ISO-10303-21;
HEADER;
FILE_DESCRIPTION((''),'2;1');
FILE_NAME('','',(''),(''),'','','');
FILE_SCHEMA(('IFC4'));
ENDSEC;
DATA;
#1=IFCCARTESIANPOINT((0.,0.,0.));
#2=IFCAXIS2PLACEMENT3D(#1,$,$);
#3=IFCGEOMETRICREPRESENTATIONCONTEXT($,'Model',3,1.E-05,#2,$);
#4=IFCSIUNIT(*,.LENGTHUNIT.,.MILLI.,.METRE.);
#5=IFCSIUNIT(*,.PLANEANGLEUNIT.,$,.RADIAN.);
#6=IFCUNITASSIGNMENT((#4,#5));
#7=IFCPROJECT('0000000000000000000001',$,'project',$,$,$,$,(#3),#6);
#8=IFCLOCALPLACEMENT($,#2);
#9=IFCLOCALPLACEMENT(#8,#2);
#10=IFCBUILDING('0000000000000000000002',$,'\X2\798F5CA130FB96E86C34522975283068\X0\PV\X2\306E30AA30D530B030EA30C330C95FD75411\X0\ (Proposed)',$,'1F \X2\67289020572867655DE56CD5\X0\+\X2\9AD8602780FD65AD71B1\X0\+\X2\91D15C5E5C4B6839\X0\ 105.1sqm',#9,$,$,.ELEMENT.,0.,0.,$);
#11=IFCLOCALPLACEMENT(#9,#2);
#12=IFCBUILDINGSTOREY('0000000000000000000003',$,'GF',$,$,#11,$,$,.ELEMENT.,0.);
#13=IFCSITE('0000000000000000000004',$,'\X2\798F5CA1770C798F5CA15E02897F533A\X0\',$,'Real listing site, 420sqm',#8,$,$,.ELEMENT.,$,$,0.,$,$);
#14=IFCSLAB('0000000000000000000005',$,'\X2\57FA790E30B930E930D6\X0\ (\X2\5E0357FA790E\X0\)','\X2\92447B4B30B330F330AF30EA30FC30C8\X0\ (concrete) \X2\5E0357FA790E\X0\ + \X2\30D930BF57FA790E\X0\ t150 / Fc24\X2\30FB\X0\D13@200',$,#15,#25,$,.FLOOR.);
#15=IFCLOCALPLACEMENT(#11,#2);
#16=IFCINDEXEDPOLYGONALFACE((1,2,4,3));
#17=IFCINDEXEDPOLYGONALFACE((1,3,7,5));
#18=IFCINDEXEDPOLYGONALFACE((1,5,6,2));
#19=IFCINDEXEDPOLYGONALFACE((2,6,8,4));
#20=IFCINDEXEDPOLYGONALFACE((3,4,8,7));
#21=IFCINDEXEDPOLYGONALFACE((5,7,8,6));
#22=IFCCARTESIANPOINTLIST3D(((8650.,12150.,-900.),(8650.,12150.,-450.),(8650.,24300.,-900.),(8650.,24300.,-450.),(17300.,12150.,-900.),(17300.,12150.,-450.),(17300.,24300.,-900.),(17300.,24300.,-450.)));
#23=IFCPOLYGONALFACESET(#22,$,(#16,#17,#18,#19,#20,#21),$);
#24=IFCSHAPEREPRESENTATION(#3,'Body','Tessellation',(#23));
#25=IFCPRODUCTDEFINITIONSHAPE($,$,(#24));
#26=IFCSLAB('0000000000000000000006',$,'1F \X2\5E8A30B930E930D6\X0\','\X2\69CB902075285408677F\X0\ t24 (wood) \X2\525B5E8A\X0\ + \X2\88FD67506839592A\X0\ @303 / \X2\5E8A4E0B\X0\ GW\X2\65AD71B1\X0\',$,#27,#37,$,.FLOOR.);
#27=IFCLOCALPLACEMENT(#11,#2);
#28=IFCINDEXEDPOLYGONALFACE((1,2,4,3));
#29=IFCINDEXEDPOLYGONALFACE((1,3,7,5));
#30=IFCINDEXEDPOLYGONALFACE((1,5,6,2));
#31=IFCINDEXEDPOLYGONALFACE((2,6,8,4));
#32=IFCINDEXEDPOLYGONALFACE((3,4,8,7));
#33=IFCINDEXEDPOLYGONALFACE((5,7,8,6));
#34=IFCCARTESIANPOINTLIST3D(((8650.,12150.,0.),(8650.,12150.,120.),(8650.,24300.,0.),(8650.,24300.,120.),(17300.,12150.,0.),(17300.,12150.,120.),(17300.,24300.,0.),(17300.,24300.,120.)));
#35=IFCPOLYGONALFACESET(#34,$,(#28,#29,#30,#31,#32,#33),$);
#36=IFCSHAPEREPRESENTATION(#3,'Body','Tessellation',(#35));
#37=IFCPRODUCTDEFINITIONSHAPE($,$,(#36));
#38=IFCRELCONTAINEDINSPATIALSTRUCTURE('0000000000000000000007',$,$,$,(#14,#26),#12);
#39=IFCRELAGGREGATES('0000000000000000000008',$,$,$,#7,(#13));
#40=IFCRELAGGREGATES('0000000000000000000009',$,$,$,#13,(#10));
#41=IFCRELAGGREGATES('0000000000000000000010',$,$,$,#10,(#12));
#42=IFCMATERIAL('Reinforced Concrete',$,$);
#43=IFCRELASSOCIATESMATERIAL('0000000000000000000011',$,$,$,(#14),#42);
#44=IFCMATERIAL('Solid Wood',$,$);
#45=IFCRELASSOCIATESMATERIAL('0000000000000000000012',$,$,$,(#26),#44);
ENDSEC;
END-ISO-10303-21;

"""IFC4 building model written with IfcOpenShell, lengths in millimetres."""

from ifc_helpers import new_model, si_unit, frame, frame_2d, origin, place, context, project, spatial, rectangle, extrude, material, element, save


model = new_model("IFC4")

# Units and contexts
model_context = context("Model", 3, precision=1e-05, world=origin())
ifc_project = project(units=[si_unit("LENGTHUNIT", "METRE", prefix="MILLI"), si_unit("PLANEANGLEUNIT", "RADIAN")], contexts=[model_context])

# Site, building, storey
site_placement = place(None, origin())
site = spatial("IfcSite", under=ifc_project, at=site_placement, Name="福岡県福岡市西区", ObjectType="Real listing site, 420sqm", CompositionType="ELEMENT", RefElevation=0.0)
building_placement = place(site_placement, origin())
building = spatial("IfcBuilding", under=site, at=building_placement, Name="福岡・雨水利用とPVのオフグリッド志向 (Proposed)", ObjectType="1F 木造在来工法+高性能断熱+金属屋根 105.1sqm", CompositionType="ELEMENT", ElevationOfRefHeight=0.0, ElevationOfTerrain=0.0)
storey_placement = place(building_placement, origin())
storey = spatial("IfcBuildingStorey", under=building, at=storey_placement, Name="GF", CompositionType="ELEMENT", Elevation=0.0)

# Shared definitions
ifc_material_1 = material(Name="Solid Wood")

# Slabs
ifc_material_2 = material(Name="Reinforced Concrete")
slab_1_placement = place(storey_placement, frame((4325.0, 6075.0, -450.0)))
element("IfcSlab", 1, at=slab_1_placement, inside=storey, material=ifc_material_2, Name="基礎スラブ (布基礎)", Description="鉄筋コンクリート (concrete) 布基礎 + ベタ基礎 t150 / Fc24・D13@200", PredefinedType="FLOOR", context=model_context, shape_type="SweptSolid", body=[
    extrude(rectangle(XDim=8650.0, YDim=12150.0, at=frame_2d((4325.0, 6075.0))), frame((4325.0, 6075.0, -450.0)), (0.0, 0.0, 1.0), 450.0),
])
slab_2_placement = place(storey_placement, frame((4325.0, 6075.0, 0.0)))
element("IfcSlab", 2, at=slab_2_placement, inside=storey, material=ifc_material_1, Name="1F 床スラブ", Description="構造用合板 t24 (wood) 剛床 + 製材根太 @303 / 床下 GW断熱", PredefinedType="FLOOR", context=model_context, shape_type="SweptSolid", body=[
    extrude(rectangle(XDim=8650.0, YDim=12150.0, at=frame_2d((4325.0, 6075.0))), frame((4325.0, 6075.0, 0.0)), (0.0, 0.0, 1.0), 120.0),
])

save(model, "model.ifc")
